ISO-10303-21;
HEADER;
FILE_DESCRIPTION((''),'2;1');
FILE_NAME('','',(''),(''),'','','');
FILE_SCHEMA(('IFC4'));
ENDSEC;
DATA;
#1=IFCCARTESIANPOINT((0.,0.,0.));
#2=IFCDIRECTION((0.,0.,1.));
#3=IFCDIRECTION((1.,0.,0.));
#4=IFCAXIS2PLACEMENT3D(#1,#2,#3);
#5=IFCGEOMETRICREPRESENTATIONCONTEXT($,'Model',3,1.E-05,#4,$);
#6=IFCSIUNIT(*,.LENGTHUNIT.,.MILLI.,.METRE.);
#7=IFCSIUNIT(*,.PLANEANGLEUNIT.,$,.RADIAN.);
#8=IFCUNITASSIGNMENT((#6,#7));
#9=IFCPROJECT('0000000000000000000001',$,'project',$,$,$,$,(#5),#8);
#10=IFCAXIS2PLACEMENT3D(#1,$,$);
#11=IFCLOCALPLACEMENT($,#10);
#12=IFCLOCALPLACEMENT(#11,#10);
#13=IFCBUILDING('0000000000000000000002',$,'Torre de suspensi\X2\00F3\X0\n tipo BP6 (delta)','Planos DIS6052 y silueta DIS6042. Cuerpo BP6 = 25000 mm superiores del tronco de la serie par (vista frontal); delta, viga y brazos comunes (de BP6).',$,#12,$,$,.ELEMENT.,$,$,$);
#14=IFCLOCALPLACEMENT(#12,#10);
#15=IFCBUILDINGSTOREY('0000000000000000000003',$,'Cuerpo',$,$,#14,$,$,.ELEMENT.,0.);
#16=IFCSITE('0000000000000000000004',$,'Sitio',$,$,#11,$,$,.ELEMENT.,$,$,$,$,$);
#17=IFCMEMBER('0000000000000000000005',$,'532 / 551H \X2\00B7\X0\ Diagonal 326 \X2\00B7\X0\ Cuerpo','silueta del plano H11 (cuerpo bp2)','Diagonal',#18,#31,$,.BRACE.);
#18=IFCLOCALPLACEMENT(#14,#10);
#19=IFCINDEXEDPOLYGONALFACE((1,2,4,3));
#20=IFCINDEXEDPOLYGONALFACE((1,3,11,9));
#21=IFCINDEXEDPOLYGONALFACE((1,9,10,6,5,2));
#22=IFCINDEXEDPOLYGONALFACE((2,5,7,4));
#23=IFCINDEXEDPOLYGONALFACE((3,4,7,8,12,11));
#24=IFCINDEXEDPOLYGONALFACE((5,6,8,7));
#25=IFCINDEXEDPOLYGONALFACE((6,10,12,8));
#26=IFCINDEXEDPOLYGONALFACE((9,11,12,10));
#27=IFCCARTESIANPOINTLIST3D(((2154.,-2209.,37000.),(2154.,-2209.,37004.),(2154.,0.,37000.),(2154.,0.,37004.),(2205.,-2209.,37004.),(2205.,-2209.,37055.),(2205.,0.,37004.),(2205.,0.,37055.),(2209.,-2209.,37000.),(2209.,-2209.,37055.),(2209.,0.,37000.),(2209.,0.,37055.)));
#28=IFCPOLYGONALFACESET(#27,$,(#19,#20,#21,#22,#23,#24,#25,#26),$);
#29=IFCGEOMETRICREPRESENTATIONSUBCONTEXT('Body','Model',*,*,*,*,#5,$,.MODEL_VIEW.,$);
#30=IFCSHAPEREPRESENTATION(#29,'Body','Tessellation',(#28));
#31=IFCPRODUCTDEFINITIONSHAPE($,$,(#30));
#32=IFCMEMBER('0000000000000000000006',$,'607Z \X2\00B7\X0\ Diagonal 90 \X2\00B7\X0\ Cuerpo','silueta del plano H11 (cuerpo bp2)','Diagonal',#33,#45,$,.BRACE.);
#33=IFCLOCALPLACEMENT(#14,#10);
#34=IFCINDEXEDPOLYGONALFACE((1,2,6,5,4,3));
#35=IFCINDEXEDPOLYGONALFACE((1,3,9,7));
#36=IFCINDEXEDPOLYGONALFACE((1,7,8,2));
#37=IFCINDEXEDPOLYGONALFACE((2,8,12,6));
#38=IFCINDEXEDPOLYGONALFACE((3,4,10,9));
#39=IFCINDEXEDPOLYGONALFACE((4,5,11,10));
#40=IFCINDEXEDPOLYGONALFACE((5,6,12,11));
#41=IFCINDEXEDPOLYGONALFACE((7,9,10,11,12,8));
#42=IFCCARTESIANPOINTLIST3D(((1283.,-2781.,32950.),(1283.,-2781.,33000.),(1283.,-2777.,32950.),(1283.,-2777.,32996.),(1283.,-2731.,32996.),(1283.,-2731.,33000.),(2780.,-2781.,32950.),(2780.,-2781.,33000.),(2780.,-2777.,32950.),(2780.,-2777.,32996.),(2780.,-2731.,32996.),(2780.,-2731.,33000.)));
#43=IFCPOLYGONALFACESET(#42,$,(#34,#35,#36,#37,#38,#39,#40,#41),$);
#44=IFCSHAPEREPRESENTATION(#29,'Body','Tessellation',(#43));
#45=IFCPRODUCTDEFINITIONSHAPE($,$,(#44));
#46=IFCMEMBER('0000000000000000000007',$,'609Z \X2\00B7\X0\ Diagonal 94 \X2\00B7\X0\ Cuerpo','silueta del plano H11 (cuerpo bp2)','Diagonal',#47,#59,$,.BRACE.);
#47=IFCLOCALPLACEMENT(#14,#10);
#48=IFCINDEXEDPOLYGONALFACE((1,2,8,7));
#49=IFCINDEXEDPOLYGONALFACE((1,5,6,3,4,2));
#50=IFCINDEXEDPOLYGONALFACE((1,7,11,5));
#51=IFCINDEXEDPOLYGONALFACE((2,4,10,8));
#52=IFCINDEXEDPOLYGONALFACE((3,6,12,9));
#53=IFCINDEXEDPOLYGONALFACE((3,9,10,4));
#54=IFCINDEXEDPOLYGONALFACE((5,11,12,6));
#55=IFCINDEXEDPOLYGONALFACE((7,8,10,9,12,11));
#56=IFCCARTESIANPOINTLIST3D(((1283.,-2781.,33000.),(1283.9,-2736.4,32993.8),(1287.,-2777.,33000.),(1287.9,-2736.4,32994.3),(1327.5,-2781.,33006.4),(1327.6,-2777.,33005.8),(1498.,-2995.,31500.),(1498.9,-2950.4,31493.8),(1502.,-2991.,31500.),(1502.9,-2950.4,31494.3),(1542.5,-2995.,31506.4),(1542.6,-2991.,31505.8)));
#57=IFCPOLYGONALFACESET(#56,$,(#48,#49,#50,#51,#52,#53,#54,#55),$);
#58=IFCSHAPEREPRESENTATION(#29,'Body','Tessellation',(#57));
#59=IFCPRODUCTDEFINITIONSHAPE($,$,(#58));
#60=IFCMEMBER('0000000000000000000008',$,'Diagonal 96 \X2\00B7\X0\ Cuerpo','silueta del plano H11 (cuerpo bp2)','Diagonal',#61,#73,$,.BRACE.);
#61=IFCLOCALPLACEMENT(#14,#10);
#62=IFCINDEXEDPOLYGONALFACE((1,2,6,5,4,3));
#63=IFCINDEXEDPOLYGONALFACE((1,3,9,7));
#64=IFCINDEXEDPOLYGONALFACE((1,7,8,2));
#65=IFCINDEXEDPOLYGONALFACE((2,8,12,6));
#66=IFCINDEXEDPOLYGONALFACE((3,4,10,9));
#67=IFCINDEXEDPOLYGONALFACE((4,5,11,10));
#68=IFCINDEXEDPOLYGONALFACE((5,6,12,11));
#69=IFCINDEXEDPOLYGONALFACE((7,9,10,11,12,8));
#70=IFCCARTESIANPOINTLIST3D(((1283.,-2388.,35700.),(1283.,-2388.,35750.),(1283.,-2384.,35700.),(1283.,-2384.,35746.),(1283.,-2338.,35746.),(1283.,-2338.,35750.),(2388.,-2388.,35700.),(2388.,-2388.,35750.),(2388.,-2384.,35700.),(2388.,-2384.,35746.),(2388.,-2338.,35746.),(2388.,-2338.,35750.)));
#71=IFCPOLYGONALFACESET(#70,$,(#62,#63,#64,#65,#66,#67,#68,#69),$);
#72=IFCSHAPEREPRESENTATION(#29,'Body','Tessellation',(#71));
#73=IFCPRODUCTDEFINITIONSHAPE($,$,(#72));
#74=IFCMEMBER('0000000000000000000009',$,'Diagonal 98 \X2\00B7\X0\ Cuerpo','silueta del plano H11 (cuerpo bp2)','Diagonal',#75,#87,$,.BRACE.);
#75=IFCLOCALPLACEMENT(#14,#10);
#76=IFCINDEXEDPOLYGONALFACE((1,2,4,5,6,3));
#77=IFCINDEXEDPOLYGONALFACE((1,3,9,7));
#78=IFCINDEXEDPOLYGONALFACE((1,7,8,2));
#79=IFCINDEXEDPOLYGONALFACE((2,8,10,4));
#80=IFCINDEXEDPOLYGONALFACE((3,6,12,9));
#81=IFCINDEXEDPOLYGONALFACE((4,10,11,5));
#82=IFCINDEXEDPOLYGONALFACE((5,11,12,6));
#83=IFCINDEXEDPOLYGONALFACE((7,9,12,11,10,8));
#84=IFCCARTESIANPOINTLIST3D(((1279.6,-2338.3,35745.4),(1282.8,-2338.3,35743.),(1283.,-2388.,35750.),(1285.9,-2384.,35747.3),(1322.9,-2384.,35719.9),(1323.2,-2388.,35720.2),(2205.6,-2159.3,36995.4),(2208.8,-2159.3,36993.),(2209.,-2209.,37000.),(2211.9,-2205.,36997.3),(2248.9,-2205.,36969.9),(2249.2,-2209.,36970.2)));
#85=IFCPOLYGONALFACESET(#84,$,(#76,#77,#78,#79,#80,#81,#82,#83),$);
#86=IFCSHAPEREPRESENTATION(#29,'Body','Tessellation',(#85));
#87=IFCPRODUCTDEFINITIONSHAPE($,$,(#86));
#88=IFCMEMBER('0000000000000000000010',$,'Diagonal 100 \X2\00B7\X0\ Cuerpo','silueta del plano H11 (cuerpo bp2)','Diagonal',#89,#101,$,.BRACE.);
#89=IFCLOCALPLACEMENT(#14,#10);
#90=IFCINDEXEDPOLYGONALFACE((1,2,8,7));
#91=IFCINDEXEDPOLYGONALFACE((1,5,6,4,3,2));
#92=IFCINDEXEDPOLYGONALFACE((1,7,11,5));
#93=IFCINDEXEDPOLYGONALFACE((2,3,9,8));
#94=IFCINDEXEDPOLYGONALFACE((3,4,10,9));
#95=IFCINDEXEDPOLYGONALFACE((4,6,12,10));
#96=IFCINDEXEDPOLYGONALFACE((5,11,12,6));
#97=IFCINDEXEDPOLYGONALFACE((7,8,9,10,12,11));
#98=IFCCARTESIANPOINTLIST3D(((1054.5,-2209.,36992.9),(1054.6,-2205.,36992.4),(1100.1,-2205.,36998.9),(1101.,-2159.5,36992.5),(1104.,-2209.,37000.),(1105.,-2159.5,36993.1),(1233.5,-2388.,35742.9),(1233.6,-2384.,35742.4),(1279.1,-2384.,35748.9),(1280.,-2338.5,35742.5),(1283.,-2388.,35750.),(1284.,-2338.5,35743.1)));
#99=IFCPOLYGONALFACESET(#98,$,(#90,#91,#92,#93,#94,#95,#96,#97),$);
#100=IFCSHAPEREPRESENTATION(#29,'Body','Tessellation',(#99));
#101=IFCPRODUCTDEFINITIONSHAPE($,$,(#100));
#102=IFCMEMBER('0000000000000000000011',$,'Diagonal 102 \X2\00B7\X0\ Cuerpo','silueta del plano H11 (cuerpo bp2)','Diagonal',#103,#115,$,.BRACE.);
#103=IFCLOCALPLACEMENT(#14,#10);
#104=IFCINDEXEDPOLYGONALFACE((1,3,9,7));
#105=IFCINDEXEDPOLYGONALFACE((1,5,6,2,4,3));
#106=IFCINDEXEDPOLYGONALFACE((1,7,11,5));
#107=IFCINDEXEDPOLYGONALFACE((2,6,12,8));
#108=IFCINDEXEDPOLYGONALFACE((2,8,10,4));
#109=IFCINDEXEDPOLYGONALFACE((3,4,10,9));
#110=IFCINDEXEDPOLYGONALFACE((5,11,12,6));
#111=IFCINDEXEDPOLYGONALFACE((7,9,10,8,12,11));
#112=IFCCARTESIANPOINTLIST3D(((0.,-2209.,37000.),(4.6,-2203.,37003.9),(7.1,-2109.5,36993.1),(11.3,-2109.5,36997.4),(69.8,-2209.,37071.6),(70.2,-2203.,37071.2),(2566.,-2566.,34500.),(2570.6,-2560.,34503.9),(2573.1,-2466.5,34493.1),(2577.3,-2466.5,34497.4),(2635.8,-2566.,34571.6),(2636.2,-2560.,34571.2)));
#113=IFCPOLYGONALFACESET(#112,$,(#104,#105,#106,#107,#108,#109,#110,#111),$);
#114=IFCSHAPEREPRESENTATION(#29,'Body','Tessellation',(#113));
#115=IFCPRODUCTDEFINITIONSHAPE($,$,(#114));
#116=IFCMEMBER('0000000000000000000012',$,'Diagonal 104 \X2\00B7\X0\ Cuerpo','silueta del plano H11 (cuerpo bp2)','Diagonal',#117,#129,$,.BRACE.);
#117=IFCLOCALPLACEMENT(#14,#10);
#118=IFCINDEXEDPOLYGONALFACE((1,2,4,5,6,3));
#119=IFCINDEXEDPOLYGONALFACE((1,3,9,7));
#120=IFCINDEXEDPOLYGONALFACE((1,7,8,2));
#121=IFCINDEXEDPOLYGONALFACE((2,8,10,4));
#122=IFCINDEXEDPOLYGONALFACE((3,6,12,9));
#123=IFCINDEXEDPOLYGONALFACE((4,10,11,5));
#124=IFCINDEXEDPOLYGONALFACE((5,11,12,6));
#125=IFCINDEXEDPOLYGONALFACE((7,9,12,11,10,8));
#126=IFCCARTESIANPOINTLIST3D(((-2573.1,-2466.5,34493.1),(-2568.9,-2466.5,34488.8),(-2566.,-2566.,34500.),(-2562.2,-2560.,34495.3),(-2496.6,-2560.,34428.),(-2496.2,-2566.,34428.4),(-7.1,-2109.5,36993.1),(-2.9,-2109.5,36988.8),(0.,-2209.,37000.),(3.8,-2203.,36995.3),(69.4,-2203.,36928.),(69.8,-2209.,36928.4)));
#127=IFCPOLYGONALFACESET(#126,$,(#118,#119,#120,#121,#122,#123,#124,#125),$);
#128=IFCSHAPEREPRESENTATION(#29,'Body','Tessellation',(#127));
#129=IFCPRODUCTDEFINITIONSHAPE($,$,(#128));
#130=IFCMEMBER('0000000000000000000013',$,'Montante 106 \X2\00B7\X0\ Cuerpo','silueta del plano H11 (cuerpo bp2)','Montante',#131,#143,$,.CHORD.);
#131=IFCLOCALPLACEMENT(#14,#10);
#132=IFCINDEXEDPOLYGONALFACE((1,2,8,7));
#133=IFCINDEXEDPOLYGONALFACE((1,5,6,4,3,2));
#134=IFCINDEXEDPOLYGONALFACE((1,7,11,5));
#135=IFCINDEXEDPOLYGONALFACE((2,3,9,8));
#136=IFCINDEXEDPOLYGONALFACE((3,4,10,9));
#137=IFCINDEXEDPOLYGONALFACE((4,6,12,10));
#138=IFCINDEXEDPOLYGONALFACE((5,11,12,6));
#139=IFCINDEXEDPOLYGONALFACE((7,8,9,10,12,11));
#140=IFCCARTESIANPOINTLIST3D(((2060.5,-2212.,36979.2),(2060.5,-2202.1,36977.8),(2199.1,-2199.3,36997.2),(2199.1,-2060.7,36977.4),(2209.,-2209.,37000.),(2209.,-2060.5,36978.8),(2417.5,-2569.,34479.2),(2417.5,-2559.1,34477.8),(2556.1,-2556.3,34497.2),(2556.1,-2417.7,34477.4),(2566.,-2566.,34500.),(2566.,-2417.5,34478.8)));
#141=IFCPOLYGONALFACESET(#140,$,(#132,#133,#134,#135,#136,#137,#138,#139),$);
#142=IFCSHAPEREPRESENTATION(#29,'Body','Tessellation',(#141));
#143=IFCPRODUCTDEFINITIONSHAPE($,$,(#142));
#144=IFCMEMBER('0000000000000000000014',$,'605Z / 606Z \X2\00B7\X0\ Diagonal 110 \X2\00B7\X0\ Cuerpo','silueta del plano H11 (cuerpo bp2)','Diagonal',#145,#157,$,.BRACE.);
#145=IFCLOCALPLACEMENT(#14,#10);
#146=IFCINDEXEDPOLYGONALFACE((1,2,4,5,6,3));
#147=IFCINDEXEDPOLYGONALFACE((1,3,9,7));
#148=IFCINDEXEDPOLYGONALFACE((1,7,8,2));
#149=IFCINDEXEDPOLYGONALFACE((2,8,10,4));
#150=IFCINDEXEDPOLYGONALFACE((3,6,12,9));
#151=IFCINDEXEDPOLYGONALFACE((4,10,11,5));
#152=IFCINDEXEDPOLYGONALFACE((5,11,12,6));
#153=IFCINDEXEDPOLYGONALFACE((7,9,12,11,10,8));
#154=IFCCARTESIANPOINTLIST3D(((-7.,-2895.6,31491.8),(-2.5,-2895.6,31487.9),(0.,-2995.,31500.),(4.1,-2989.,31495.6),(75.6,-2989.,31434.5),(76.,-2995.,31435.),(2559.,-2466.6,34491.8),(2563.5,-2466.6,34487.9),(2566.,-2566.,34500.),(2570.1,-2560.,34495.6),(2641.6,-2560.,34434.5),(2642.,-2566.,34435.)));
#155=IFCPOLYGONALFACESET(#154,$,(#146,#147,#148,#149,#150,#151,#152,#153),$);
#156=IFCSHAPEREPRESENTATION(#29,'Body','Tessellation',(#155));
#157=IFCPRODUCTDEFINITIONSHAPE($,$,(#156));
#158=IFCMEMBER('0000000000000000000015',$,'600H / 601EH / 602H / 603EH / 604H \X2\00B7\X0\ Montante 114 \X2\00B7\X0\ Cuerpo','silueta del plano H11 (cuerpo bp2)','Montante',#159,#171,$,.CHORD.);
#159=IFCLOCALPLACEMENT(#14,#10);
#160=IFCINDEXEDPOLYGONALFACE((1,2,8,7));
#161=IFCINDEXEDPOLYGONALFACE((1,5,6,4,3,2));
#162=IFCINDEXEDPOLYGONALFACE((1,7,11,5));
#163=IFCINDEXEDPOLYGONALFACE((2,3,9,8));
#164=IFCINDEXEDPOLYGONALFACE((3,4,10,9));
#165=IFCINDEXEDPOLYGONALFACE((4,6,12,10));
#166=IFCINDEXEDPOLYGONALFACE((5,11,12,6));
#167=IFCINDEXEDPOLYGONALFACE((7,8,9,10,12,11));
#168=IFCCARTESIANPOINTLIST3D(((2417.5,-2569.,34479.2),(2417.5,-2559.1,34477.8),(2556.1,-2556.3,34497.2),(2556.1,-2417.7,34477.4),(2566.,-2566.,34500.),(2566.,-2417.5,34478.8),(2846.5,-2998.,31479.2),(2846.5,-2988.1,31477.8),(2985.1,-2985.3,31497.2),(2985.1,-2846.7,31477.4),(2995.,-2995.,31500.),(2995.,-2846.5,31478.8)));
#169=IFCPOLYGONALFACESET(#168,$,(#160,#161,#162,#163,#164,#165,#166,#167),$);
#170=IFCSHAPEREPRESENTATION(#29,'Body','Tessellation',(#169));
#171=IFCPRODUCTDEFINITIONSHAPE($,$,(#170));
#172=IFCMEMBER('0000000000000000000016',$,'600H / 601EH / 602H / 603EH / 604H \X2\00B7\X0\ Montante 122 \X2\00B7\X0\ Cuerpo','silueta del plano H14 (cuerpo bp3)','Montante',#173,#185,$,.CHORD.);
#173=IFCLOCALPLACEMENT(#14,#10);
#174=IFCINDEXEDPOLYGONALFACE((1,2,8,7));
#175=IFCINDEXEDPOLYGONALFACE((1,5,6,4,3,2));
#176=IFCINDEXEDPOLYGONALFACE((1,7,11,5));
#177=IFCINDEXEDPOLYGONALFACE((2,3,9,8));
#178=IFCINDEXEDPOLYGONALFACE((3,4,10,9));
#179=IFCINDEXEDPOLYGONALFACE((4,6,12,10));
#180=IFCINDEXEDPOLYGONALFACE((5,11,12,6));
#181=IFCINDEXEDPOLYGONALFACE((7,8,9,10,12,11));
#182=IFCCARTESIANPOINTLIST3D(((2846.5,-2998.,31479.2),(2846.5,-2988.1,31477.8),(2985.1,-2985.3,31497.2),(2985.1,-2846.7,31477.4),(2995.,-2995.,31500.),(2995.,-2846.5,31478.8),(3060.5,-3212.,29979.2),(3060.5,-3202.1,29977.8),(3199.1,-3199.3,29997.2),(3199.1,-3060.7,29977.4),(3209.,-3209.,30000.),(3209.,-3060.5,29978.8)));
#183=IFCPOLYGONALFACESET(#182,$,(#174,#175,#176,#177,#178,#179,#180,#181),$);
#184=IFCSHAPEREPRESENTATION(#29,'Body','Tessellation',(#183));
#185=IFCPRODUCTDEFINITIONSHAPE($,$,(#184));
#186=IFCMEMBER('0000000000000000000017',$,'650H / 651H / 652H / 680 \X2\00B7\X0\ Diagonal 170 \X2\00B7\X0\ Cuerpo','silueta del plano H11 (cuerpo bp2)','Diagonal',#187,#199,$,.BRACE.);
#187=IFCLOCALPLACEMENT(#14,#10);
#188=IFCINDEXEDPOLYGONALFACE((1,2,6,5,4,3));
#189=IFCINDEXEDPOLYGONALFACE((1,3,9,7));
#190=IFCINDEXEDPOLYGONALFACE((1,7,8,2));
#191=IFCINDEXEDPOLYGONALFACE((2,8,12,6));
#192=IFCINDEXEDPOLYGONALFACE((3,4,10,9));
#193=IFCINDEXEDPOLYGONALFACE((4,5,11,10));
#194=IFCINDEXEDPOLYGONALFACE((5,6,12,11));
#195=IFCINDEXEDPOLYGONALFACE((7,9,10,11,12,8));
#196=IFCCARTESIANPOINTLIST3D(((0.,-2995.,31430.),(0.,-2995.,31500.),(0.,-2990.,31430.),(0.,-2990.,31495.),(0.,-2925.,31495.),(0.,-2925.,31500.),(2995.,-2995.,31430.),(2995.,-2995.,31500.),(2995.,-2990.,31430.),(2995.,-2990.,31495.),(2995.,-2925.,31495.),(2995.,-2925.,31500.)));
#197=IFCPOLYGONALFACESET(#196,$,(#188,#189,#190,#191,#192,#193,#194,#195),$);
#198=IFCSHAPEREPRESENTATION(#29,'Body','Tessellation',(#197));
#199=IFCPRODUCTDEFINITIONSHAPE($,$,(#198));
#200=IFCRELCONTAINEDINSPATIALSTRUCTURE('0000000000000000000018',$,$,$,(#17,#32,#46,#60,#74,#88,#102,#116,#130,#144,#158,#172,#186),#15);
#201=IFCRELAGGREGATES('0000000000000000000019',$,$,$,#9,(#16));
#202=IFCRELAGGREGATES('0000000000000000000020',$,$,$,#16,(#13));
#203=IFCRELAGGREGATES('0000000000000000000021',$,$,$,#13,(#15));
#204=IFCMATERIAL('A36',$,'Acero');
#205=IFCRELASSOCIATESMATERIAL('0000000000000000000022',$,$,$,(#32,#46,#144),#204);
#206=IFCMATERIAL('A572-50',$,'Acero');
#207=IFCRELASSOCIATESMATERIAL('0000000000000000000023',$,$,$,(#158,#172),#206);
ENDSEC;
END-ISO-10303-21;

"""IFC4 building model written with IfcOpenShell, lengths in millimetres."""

from ifc_helpers import new_model, si_unit, frame, frame_2d, origin, origin_with_axes, place, context, subcontext, project, spatial, l_section, extrude, material, element, save


model = new_model("IFC4")

# Units and contexts
model_context = context("Model", 3, precision=1e-05, world=origin_with_axes())
body_context = subcontext(model_context, "Body", "Model", "MODEL_VIEW")
ifc_project = project(units=[si_unit("LENGTHUNIT", "METRE", prefix="MILLI"), si_unit("PLANEANGLEUNIT", "RADIAN")], contexts=[model_context])

# Site, building, storey
site_placement = place(None, origin())
site = spatial("IfcSite", under=ifc_project, at=site_placement, Name="Sitio", CompositionType="ELEMENT")
building_placement = place(site_placement, origin())
building = spatial("IfcBuilding", under=site, at=building_placement, Name="Torre de suspensión tipo BP6 (delta)", Description="Planos DIS6052 y silueta DIS6042. Cuerpo BP6 = 25000 mm superiores del tronco de la serie par (vista frontal); delta, viga y brazos comunes (de BP6).", CompositionType="ELEMENT")
storey_placement = place(building_placement, origin())
storey = spatial("IfcBuildingStorey", under=building, at=storey_placement, Name="Cuerpo", CompositionType="ELEMENT", Elevation=0.0)

# Members
member_1_placement = place(storey_placement, frame((2209.0, -2209.0, 37000.0), z_axis=(0.0, 1.0, 0.0), x_axis=(-1.0, 0.0, 0.0)))
element("IfcMember", 1, at=member_1_placement, inside=storey, Name="532 / 551H · Diagonal 326 · Cuerpo", Description="silueta del plano H11 (cuerpo bp2)", ObjectType="Diagonal", PredefinedType="BRACE", context=body_context, shape_type="SweptSolid", body=[
    extrude(l_section(Depth=55.0, Width=55.0, Thickness=4.0, at=frame_2d((27.5, 27.5))), None, (0.0, 0.0, 1.0), 2209.0),
])
ifc_material_1 = material(Name="A36", Category="Acero")
member_2_placement = place(storey_placement, frame((2780.0, -2781.0, 33000.0), z_axis=(-1.0, 0.0, 0.0), x_axis=(0.0, 1.0, 0.0)))
element("IfcMember", 2, at=member_2_placement, inside=storey, material=ifc_material_1, Name="607Z · Diagonal 90 · Cuerpo", Description="silueta del plano H11 (cuerpo bp2)", ObjectType="Diagonal", PredefinedType="BRACE", context=body_context, shape_type="SweptSolid", body=[
    extrude(l_section(Depth=50.0, Width=50.0, Thickness=4.0, at=frame_2d((25.0, 25.0))), None, (0.0, 0.0, 1.0), 1497.0),
])
member_3_placement = place(storey_placement, frame((1283.0, -2781.0, 33000.0), z_axis=(0.140489, -0.139836, -0.980157), x_axis=(0.01984, 0.990175, -0.138421)))
element("IfcMember", 3, at=member_3_placement, inside=storey, material=ifc_material_1, Name="609Z · Diagonal 94 · Cuerpo", Description="silueta del plano H11 (cuerpo bp2)", ObjectType="Diagonal", PredefinedType="BRACE", context=body_context, shape_type="SweptSolid", body=[
    extrude(l_section(Depth=45.0, Width=45.0, Thickness=4.0, at=frame_2d((22.5, 22.5))), None, (0.0, 0.0, 1.0), 1530.4),
])
member_4_placement = place(storey_placement, frame((2388.0, -2388.0, 35750.0), z_axis=(-1.0, 0.0, 0.0), x_axis=(0.0, 1.0, 0.0)))
element("IfcMember", 4, at=member_4_placement, inside=storey, Name="Diagonal 96 · Cuerpo", Description="silueta del plano H11 (cuerpo bp2)", ObjectType="Diagonal", PredefinedType="BRACE", context=body_context, shape_type="SweptSolid", body=[
    extrude(l_section(Depth=50.0, Width=50.0, Thickness=4.0, at=frame_2d((25.0, 25.0))), None, (0.0, 0.0, 1.0), 1105.0),
])
member_5_placement = place(storey_placement, frame((2209.0, -2209.0, 37000.0), z_axis=(-0.591356, -0.114312, -0.798267), x_axis=(-0.068045, 0.993445, -0.091854)))
element("IfcMember", 5, at=member_5_placement, inside=storey, Name="Diagonal 98 · Cuerpo", Description="silueta del plano H11 (cuerpo bp2)", ObjectType="Diagonal", PredefinedType="BRACE", context=body_context, shape_type="SweptSolid", body=[
    extrude(l_section(Depth=50.0, Width=50.0, Thickness=4.0, at=frame_2d((25.0, 25.0))), None, (0.0, 0.0, 1.0), 1565.9),
])
member_6_placement = place(storey_placement, frame((1283.0, -2388.0, 35750.0), z_axis=(-0.140351, 0.140351, 0.980104), x_axis=(0.019895, 0.990102, -0.138934)))
element("IfcMember", 6, at=member_6_placement, inside=storey, Name="Diagonal 100 · Cuerpo", Description="silueta del plano H11 (cuerpo bp2)", ObjectType="Diagonal", PredefinedType="BRACE", context=body_context, shape_type="SweptSolid", body=[
    extrude(l_section(Depth=50.0, Width=50.0, Thickness=4.0, at=frame_2d((25.0, 25.0))), None, (0.0, 0.0, 1.0), 1275.4),
])
for number, where, z_axis, x_axis, name in (
    (7, (0.0, -2209.0, 37000.0), (0.712728, -0.09916, -0.694396), (0.071024, 0.995072, -0.069197), "Diagonal 102 · Cuerpo"),
    (8, (0.0, -2209.0, 37000.0), (-0.712728, -0.09916, -0.694396), (-0.071024, 0.995072, -0.069197), "Diagonal 104 · Cuerpo"),
):
    element("IfcMember", number, at=place(storey_placement, frame(where, z_axis=z_axis, x_axis=x_axis)), inside=storey, Name=name, Description="silueta del plano H11 (cuerpo bp2)", ObjectType="Diagonal", PredefinedType="BRACE", context=body_context, shape_type="SweptSolid", body=[
        extrude(l_section(Depth=100.0, Width=100.0, Thickness=6.0, at=frame_2d((50.0, 50.0))), None, (0.0, 0.0, 1.0), 3600.3),
    ])
member_7_placement = place(storey_placement, frame((2209.0, -2209.0, 37000.0), z_axis=(0.139974, -0.139974, -0.980211), x_axis=(-0.990155, -0.019788, -0.138568)))
element("IfcMember", 9, at=member_7_placement, inside=storey, Name="Montante 106 · Cuerpo", Description="silueta del plano H11 (cuerpo bp2)", ObjectType="Montante", PredefinedType="CHORD", context=body_context, shape_type="SweptSolid", body=[
    extrude(l_section(Depth=150.0, Width=150.0, Thickness=10.0, at=frame_2d((75.0, 75.0))), None, (0.0, 0.0, 1.0), 2550.5),
])
member_8_placement = place(storey_placement, frame((2566.0, -2566.0, 34500.0), z_axis=(-0.646194, -0.108035, -0.755488), x_axis=(-0.070222, 0.994147, -0.082099)))
element("IfcMember", 10, at=member_8_placement, inside=storey, material=ifc_material_1, Name="605Z / 606Z · Diagonal 110 · Cuerpo", Description="silueta del plano H11 (cuerpo bp2)", ObjectType="Diagonal", PredefinedType="BRACE", context=body_context, shape_type="SweptSolid", body=[
    extrude(l_section(Depth=100.0, Width=100.0, Thickness=6.0, at=frame_2d((50.0, 50.0))), None, (0.0, 0.0, 1.0), 3970.9),
])
ifc_material_2 = material(Name="A572-50", Category="Acero")
member_9_placement = place(storey_placement, frame((2566.0, -2566.0, 34500.0), z_axis=(0.140163, -0.140163, -0.980158), x_axis=(-0.990129, -0.019841, -0.138751)))
element("IfcMember", 11, at=member_9_placement, inside=storey, material=ifc_material_2, Name="600H / 601EH / 602H / 603EH / 604H · Montante 114 · Cuerpo", Description="silueta del plano H11 (cuerpo bp2)", ObjectType="Montante", PredefinedType="CHORD", context=body_context, shape_type="SweptSolid", body=[
    extrude(l_section(Depth=150.0, Width=150.0, Thickness=10.0, at=frame_2d((75.0, 75.0))), None, (0.0, 0.0, 1.0), 3060.7),
])
member_10_placement = place(storey_placement, frame((2995.0, -2995.0, 31500.0), z_axis=(0.139849, -0.139849, -0.980247), x_axis=(-0.990173, -0.019752, -0.138447)))
element("IfcMember", 12, at=member_10_placement, inside=storey, material=ifc_material_2, Name="600H / 601EH / 602H / 603EH / 604H · Montante 122 · Cuerpo", Description="silueta del plano H14 (cuerpo bp3)", ObjectType="Montante", PredefinedType="CHORD", context=body_context, shape_type="SweptSolid", body=[
    extrude(l_section(Depth=150.0, Width=150.0, Thickness=10.0, at=frame_2d((75.0, 75.0))), None, (0.0, 0.0, 1.0), 1530.2),
])
member_11_placement = place(storey_placement, frame((2995.0, -2995.0, 31500.0), z_axis=(-1.0, 0.0, 0.0), x_axis=(0.0, 1.0, 0.0)))
element("IfcMember", 13, at=member_11_placement, inside=storey, Name="650H / 651H / 652H / 680 · Diagonal 170 · Cuerpo", Description="silueta del plano H11 (cuerpo bp2)", ObjectType="Diagonal", PredefinedType="BRACE", context=body_context, shape_type="SweptSolid", body=[
    extrude(l_section(Depth=70.0, Width=70.0, Thickness=5.0, at=frame_2d((35.0, 35.0))), None, (0.0, 0.0, 1.0), 2995.0),
])

save(model, "model.ifc")
